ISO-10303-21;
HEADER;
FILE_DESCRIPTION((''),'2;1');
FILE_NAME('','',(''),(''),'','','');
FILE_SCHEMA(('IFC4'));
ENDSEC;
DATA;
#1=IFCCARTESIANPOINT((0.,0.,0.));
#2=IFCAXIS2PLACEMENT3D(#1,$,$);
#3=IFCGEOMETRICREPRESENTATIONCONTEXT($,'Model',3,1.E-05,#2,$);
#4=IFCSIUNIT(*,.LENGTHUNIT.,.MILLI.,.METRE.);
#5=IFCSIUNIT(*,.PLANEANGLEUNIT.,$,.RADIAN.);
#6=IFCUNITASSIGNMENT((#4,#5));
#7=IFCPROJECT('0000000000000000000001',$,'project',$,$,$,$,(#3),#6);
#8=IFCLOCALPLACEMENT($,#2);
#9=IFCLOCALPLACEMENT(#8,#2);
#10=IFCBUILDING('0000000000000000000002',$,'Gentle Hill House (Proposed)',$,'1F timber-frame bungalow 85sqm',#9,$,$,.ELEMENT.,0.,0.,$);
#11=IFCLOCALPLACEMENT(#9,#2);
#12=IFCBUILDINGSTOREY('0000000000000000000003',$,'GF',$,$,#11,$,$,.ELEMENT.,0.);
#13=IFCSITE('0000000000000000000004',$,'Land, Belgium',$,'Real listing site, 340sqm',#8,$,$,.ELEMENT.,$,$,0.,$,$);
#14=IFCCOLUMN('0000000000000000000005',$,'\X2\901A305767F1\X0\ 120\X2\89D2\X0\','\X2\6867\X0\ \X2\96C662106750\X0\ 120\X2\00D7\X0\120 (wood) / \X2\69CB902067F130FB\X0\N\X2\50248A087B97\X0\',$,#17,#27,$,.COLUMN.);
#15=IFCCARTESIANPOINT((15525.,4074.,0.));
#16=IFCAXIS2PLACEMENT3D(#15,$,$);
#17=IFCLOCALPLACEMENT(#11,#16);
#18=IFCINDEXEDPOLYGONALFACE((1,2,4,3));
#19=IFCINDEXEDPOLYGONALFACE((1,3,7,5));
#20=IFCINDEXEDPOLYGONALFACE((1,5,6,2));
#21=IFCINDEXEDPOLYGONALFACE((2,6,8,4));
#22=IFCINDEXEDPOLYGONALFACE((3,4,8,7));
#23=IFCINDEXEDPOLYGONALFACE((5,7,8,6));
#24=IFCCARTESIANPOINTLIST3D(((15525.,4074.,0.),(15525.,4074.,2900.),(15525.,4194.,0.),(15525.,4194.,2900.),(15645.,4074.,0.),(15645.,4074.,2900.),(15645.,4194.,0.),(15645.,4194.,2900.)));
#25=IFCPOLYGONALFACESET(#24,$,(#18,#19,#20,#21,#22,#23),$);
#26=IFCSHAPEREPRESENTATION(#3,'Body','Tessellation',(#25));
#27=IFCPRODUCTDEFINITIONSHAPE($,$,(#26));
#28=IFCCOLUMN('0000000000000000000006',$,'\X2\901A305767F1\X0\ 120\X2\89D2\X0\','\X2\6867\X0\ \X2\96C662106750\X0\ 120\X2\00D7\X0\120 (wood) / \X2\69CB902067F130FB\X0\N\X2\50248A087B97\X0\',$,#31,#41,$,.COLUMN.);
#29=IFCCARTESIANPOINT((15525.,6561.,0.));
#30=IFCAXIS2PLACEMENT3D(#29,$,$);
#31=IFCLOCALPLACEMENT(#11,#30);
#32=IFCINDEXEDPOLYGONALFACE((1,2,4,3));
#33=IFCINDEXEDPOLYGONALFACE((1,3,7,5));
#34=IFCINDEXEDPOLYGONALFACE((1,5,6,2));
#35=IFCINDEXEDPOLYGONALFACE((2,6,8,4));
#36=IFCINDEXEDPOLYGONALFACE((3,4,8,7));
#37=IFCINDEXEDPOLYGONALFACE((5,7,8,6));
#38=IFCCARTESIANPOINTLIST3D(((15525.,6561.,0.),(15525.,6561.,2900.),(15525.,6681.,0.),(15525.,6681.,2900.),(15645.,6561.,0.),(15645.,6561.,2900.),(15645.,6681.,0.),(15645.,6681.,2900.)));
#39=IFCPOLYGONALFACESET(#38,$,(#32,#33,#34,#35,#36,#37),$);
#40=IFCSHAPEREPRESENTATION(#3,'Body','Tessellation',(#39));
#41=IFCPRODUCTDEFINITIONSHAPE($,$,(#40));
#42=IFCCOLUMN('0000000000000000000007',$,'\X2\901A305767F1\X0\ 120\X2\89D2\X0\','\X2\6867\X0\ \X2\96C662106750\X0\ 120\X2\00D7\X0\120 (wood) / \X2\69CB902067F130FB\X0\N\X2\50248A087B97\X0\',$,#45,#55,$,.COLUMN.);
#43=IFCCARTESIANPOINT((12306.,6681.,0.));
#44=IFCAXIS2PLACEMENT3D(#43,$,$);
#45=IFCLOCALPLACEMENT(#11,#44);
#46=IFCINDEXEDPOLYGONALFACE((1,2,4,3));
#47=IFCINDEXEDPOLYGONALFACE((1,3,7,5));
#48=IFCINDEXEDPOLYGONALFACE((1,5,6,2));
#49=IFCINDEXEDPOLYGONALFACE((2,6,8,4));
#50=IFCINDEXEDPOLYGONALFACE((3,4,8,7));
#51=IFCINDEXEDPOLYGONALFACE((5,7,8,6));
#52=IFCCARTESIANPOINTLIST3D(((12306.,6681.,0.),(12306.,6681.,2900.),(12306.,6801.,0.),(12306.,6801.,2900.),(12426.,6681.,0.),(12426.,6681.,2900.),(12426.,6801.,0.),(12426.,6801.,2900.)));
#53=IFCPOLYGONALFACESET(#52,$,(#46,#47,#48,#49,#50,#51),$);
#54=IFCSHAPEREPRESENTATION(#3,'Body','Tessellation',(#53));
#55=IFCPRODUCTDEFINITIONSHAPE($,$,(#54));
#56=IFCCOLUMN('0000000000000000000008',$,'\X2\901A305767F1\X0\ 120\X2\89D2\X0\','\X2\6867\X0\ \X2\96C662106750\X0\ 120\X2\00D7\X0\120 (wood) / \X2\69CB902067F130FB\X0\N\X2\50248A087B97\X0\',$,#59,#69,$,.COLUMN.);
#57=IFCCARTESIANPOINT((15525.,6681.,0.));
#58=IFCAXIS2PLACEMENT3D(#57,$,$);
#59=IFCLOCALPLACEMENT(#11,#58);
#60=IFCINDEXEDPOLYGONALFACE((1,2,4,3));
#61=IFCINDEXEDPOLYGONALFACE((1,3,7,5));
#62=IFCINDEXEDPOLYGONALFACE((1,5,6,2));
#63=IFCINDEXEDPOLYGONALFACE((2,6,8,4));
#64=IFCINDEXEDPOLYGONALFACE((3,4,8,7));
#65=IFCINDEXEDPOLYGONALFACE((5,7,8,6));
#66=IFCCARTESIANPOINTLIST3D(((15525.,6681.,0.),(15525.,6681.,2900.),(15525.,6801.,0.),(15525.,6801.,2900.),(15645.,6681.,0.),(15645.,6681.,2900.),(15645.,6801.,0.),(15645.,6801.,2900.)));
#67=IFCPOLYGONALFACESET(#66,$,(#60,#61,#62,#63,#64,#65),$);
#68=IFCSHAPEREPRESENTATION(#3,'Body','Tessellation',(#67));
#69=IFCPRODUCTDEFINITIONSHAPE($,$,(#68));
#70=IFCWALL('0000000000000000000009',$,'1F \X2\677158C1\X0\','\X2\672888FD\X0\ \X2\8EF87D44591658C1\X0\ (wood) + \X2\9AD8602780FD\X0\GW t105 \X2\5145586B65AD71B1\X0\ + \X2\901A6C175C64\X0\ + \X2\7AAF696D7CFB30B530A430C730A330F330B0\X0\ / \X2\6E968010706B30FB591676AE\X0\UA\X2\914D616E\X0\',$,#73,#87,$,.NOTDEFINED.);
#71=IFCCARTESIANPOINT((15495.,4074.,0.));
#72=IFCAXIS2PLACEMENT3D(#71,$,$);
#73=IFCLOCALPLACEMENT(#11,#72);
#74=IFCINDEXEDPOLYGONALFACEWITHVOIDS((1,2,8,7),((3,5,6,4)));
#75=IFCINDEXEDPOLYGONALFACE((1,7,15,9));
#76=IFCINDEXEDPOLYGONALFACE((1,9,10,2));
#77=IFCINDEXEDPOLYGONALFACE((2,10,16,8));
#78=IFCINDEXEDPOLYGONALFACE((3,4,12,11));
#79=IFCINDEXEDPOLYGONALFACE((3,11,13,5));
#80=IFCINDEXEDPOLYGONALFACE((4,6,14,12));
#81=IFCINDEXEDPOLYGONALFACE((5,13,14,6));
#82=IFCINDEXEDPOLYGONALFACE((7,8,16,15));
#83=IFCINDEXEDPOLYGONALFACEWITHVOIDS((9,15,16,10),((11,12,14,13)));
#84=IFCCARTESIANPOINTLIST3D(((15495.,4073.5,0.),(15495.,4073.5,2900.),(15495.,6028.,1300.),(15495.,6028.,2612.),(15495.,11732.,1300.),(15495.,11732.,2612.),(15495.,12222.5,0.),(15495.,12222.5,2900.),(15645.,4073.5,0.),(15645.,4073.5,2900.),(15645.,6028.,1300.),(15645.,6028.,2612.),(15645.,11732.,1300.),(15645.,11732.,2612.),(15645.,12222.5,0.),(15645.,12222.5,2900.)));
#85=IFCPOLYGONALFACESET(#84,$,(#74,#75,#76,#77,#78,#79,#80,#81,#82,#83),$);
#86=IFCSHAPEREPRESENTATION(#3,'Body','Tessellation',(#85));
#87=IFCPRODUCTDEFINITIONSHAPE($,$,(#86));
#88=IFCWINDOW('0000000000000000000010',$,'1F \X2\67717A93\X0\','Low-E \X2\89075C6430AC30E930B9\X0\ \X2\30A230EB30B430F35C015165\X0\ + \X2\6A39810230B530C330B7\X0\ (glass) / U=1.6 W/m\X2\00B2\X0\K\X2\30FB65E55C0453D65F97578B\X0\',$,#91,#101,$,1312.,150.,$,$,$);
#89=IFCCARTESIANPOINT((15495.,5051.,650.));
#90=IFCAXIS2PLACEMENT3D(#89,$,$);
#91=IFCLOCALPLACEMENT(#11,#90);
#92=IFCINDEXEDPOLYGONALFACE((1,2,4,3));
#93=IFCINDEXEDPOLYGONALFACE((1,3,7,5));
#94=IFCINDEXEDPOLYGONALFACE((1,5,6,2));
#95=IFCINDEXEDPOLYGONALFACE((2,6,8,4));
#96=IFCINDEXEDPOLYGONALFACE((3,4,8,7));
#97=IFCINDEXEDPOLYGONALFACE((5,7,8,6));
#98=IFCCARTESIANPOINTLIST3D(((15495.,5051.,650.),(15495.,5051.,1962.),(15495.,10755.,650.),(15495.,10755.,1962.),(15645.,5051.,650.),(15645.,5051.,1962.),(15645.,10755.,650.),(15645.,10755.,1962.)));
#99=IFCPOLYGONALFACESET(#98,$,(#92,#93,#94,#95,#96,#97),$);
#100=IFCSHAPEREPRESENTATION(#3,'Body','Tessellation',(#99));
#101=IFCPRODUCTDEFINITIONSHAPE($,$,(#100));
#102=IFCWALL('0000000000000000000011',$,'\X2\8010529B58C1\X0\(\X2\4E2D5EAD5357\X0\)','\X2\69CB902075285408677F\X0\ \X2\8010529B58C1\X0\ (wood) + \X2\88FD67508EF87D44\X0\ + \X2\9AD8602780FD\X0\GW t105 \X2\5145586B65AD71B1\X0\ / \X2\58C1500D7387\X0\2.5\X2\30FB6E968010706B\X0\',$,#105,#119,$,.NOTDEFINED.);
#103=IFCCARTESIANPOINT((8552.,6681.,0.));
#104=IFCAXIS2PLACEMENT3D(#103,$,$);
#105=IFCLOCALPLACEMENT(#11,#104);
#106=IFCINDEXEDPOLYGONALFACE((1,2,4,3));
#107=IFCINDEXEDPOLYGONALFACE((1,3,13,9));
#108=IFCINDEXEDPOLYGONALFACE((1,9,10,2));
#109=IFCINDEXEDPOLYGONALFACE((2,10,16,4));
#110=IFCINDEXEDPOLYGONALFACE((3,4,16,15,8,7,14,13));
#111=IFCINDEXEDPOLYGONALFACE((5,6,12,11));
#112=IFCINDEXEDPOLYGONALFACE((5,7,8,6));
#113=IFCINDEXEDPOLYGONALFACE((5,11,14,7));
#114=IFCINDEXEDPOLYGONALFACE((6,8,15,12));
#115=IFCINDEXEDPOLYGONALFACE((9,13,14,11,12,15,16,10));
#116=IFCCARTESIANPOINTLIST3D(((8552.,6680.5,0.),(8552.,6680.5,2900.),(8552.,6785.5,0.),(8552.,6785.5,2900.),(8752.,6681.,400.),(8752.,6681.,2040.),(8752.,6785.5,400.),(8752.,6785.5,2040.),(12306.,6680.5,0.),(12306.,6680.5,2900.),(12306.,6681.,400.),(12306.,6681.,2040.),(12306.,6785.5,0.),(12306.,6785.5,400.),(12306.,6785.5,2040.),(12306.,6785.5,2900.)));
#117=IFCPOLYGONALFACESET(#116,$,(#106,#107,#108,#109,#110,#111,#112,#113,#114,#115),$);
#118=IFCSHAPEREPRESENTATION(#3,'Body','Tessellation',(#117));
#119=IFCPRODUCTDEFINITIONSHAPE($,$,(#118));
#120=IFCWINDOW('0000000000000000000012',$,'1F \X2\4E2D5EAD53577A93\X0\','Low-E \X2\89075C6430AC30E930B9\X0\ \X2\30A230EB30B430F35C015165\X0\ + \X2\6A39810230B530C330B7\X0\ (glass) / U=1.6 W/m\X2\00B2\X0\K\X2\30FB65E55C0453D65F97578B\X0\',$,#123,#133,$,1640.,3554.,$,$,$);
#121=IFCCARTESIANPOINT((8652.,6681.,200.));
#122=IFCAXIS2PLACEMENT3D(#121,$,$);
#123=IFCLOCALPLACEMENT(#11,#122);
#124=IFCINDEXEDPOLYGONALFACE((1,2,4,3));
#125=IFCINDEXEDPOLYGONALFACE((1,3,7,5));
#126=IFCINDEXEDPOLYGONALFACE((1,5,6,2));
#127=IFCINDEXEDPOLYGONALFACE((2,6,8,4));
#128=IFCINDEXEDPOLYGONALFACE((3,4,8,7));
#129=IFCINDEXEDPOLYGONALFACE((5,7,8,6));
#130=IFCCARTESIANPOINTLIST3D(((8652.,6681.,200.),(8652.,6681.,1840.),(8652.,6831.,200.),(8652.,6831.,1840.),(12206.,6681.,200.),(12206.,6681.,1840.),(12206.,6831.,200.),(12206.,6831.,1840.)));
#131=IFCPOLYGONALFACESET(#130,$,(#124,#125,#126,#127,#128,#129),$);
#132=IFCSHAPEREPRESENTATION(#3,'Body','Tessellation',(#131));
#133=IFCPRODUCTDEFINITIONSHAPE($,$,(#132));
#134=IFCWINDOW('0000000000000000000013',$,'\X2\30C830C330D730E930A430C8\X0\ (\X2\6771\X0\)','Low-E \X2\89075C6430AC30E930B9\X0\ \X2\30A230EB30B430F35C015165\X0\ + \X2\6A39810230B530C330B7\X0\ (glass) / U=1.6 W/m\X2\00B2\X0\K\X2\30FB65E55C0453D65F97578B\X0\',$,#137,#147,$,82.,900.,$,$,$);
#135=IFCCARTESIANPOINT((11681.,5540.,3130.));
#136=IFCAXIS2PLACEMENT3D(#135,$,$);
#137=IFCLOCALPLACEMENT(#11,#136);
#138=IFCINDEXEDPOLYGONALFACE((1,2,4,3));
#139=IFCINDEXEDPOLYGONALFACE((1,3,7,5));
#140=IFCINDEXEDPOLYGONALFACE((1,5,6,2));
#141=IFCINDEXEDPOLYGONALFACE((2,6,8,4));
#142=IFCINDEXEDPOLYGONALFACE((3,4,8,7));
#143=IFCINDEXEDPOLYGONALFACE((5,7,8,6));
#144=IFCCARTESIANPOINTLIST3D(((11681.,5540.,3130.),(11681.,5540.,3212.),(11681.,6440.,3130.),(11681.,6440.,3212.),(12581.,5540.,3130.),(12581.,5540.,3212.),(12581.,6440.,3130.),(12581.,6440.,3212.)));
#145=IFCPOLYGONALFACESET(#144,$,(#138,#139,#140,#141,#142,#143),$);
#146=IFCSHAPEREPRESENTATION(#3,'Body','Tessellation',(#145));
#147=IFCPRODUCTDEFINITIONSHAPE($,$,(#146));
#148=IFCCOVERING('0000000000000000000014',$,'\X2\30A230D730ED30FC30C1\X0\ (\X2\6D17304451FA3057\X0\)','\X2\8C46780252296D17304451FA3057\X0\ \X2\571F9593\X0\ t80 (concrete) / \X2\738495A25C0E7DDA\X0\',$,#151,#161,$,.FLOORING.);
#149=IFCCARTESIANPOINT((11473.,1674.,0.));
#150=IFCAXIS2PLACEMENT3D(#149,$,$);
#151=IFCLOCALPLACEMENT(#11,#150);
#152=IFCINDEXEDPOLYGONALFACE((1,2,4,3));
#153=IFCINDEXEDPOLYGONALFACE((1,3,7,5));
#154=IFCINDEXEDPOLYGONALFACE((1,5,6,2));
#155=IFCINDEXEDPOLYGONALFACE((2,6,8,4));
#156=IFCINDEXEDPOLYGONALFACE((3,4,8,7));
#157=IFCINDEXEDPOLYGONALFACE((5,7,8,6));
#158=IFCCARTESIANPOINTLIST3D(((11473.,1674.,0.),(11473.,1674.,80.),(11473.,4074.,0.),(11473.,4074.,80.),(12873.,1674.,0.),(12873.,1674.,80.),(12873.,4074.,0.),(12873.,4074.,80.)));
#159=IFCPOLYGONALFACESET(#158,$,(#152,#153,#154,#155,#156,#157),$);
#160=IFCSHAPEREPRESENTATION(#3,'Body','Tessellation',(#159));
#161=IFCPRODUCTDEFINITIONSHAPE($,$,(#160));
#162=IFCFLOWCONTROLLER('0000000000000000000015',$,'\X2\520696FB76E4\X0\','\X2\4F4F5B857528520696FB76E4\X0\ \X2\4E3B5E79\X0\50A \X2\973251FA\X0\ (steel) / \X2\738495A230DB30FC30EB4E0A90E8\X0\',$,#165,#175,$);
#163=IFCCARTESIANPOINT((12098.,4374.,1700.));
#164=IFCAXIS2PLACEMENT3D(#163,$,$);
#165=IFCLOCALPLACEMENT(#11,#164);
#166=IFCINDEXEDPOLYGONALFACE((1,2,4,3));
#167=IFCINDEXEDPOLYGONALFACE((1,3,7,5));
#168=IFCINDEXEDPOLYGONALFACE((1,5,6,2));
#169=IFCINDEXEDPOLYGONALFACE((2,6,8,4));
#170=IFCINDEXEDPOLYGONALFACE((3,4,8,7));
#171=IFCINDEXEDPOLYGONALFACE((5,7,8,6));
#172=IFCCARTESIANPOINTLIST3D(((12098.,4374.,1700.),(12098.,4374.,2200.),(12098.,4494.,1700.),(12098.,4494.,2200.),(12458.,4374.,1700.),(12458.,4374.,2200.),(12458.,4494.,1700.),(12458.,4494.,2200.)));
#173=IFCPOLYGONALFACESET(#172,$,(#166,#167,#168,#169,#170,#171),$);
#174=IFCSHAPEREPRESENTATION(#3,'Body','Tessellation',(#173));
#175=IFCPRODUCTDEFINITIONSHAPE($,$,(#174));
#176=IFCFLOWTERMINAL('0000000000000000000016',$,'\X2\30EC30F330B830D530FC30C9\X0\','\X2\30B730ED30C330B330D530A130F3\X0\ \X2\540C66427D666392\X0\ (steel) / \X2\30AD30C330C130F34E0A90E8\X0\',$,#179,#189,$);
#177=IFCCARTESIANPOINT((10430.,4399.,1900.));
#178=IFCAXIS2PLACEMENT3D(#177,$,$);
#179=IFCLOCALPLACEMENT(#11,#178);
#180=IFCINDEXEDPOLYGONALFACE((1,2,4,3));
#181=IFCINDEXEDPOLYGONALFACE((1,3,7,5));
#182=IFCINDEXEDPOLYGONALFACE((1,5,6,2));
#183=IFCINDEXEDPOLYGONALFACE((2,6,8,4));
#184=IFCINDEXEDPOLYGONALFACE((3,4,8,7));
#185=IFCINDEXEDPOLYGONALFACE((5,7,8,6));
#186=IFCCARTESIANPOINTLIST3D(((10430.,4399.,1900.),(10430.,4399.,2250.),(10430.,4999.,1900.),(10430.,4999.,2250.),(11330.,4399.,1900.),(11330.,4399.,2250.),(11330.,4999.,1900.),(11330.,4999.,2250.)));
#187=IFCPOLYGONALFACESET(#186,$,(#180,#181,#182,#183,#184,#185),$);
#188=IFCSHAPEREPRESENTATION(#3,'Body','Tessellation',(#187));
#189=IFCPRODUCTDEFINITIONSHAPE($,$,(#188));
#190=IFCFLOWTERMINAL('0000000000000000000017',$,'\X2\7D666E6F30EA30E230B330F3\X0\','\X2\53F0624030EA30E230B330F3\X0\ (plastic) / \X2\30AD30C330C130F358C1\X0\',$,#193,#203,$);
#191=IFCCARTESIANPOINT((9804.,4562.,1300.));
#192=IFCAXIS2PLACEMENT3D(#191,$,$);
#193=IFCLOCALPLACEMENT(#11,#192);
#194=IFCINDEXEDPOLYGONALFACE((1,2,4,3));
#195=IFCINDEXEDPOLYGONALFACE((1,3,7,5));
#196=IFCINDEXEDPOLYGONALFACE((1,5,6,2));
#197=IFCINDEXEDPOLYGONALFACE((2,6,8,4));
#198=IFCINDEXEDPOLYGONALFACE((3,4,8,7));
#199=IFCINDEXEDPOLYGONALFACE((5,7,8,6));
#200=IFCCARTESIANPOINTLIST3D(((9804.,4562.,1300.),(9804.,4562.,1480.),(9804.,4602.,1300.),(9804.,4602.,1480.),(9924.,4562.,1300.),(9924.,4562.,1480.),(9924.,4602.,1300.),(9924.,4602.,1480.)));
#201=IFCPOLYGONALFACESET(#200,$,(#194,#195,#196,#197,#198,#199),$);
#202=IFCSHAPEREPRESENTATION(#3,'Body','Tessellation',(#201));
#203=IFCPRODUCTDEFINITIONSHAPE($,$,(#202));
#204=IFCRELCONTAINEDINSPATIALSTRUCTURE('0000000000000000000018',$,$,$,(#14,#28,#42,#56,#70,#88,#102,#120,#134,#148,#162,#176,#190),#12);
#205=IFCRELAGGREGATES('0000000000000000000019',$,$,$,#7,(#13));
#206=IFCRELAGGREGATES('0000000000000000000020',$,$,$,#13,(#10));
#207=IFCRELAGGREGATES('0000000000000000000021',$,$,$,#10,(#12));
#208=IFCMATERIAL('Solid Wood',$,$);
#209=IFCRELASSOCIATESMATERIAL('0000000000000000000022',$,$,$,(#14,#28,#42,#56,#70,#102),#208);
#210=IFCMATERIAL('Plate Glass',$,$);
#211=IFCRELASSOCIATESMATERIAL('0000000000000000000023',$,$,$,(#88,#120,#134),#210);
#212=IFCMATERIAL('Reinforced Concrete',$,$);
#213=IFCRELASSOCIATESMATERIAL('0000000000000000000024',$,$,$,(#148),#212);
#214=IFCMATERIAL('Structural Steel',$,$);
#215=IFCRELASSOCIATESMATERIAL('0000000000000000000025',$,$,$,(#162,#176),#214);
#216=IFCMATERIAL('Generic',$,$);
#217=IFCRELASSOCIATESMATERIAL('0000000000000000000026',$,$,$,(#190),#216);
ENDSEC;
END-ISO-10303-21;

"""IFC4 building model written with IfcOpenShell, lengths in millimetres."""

from ifc_helpers import new_model, si_unit, frame, frame_2d, origin, place, context, project, spatial, rectangle, extrude, material, element, fill, save


model = new_model("IFC4")

# Units and contexts
model_context = context("Model", 3, precision=1e-05, world=origin())
ifc_project = project(units=[si_unit("LENGTHUNIT", "METRE", prefix="MILLI"), si_unit("PLANEANGLEUNIT", "RADIAN")], contexts=[model_context])

# Site, building, storey
site_placement = place(None, origin())
site = spatial("IfcSite", under=ifc_project, at=site_placement, Name="Land, Belgium", ObjectType="Real listing site, 340sqm", CompositionType="ELEMENT", RefElevation=0.0)
building_placement = place(site_placement, origin())
building = spatial("IfcBuilding", under=site, at=building_placement, Name="Gentle Hill House (Proposed)", ObjectType="1F timber-frame bungalow 85sqm", CompositionType="ELEMENT", ElevationOfRefHeight=0.0, ElevationOfTerrain=0.0)
storey_placement = place(building_placement, origin())
storey = spatial("IfcBuildingStorey", under=building, at=storey_placement, Name="GF", CompositionType="ELEMENT", Elevation=0.0)

# Columns
ifc_material_1 = material(Name="Solid Wood")
column_1_placement = place(storey_placement, frame((15525.0, 4074.0, 0.0)))
element("IfcColumn", 1, at=column_1_placement, inside=storey, material=ifc_material_1, Name="通し柱 120角", Description="桧 集成材 120×120 (wood) / 構造柱・N値計算", PredefinedType="COLUMN", context=model_context, shape_type="SweptSolid", body=[
    extrude(rectangle(XDim=120.0, YDim=120.0, at=frame_2d((60.0, 60.0))), frame((15525.0, 4074.0, 0.0)), (0.0, 0.0, 1.0), 2900.0),
])
column_2_placement = place(storey_placement, frame((15525.0, 6561.0, 0.0)))
element("IfcColumn", 2, at=column_2_placement, inside=storey, material=ifc_material_1, Name="通し柱 120角", Description="桧 集成材 120×120 (wood) / 構造柱・N値計算", PredefinedType="COLUMN", context=model_context, shape_type="SweptSolid", body=[
    extrude(rectangle(XDim=120.0, YDim=120.0, at=frame_2d((60.0, 60.0))), frame((15525.0, 6561.0, 0.0)), (0.0, 0.0, 1.0), 2900.0),
])
column_3_placement = place(storey_placement, frame((12306.0, 6681.0, 0.0)))
element("IfcColumn", 3, at=column_3_placement, inside=storey, material=ifc_material_1, Name="通し柱 120角", Description="桧 集成材 120×120 (wood) / 構造柱・N値計算", PredefinedType="COLUMN", context=model_context, shape_type="SweptSolid", body=[
    extrude(rectangle(XDim=120.0, YDim=120.0, at=frame_2d((60.0, 60.0))), frame((12306.0, 6681.0, 0.0)), (0.0, 0.0, 1.0), 2900.0),
])
column_4_placement = place(storey_placement, frame((15525.0, 6681.0, 0.0)))
element("IfcColumn", 4, at=column_4_placement, inside=storey, material=ifc_material_1, Name="通し柱 120角", Description="桧 集成材 120×120 (wood) / 構造柱・N値計算", PredefinedType="COLUMN", context=model_context, shape_type="SweptSolid", body=[
    extrude(rectangle(XDim=120.0, YDim=120.0, at=frame_2d((60.0, 60.0))), frame((15525.0, 6681.0, 0.0)), (0.0, 0.0, 1.0), 2900.0),
])

# Walls, openings, windows
wall_1_placement = place(storey_placement, frame((15495.0, 4074.0, 0.0)))
wall_1 = element("IfcWall", 5, at=wall_1_placement, inside=storey, material=ifc_material_1, Name="1F 東壁", Description="木製 軸組外壁 (wood) + 高性能GW t105 充填断熱 + 通気層 + 窯業系サイディング / 準耐火・外皮UA配慮", PredefinedType="NOTDEFINED", context=model_context, shape_type="SweptSolid", body=[
    extrude(rectangle(XDim=150.0, YDim=8149.0, at=frame_2d((75.0, 4074.0))), frame((15495.0, 4074.0, 0.0)), (0.0, 0.0, 1.0), 2900.0),
])
opening_1_placement = place(storey_placement, frame((15495.0, 5051.0, 650.0)))
opening_1 = element("IfcOpeningElement", 6, at=opening_1_placement, cuts=wall_1, PredefinedType="NOTDEFINED", context=model_context, shape_type="SweptSolid", body=[
    extrude(rectangle(XDim=150.0, YDim=5704.0, at=frame_2d((75.0, 2852.0))), frame((15495.0, 5051.0, 650.0)), (0.0, 0.0, 1.0), 1312.0),
])
ifc_material_2 = material(Name="Plate Glass")
window_1_placement = place(storey_placement, frame((15495.0, 5051.0, 650.0)))
window_1 = element("IfcWindow", 7, at=window_1_placement, inside=storey, material=ifc_material_2, Name="1F 東窓", Description="Low-E 複層ガラス アルゴン封入 + 樹脂サッシ (glass) / U=1.6 W/m²K・日射取得型", OverallHeight=1312.0, OverallWidth=150.0, context=model_context, shape_type="SweptSolid", body=[
    extrude(rectangle(XDim=150.0, YDim=5704.0, at=frame_2d((75.0, 2852.0))), frame((15495.0, 5051.0, 650.0)), (0.0, 0.0, 1.0), 1312.0),
])
fill(opening_1, window_1)
wall_2_placement = place(storey_placement, frame((8552.0, 6681.0, 0.0)))
wall_2 = element("IfcWall", 8, at=wall_2_placement, inside=storey, material=ifc_material_1, Name="耐力壁(中庭南)", Description="構造用合板 耐力壁 (wood) + 製材軸組 + 高性能GW t105 充填断熱 / 壁倍率2.5・準耐火", PredefinedType="NOTDEFINED", context=model_context, shape_type="SweptSolid", body=[
    extrude(rectangle(XDim=3754.0, YDim=105.0, at=frame_2d((1877.0, 52.0))), frame((8552.0, 6681.0, 0.0)), (0.0, 0.0, 1.0), 2900.0),
])
opening_2_placement = place(storey_placement, frame((8652.0, 6681.0, 200.0)))
opening_2 = element("IfcOpeningElement", 9, at=opening_2_placement, cuts=wall_2, PredefinedType="NOTDEFINED", context=model_context, shape_type="SweptSolid", body=[
    extrude(rectangle(XDim=3554.0, YDim=150.0, at=frame_2d((1777.0, 75.0))), frame((8652.0, 6681.0, 200.0)), (0.0, 0.0, 1.0), 1640.0),
])
window_2_placement = place(storey_placement, frame((8652.0, 6681.0, 200.0)))
window_2 = element("IfcWindow", 10, at=window_2_placement, inside=storey, material=ifc_material_2, Name="1F 中庭南窓", Description="Low-E 複層ガラス アルゴン封入 + 樹脂サッシ (glass) / U=1.6 W/m²K・日射取得型", OverallHeight=1640.0, OverallWidth=3554.0, context=model_context, shape_type="SweptSolid", body=[
    extrude(rectangle(XDim=3554.0, YDim=150.0, at=frame_2d((1777.0, 75.0))), frame((8652.0, 6681.0, 200.0)), (0.0, 0.0, 1.0), 1640.0),
])
fill(opening_2, window_2)

# Window
window_3_placement = place(storey_placement, frame((11681.0, 5540.0, 3130.0)))
element("IfcWindow", 11, at=window_3_placement, inside=storey, material=ifc_material_2, Name="トップライト (東)", Description="Low-E 複層ガラス アルゴン封入 + 樹脂サッシ (glass) / U=1.6 W/m²K・日射取得型", OverallHeight=82.0, OverallWidth=900.0, context=model_context, shape_type="SweptSolid", body=[
    extrude(rectangle(XDim=900.0, YDim=900.0, at=frame_2d((450.0, 450.0))), frame((11681.0, 5540.0, 3130.0)), (0.0, 0.0, 1.0), 82.0),
])

# Shared definitions
ifc_material_3 = material(Name="Structural Steel")

# Covering
ifc_material_4 = material(Name="Reinforced Concrete")
covering_placement = place(storey_placement, frame((11473.0, 1674.0, 0.0)))
element("IfcCovering", 12, at=covering_placement, inside=storey, material=ifc_material_4, Name="アプローチ (洗い出し)", Description="豆砂利洗い出し 土間 t80 (concrete) / 玄関導線", PredefinedType="FLOORING", context=model_context, shape_type="SweptSolid", body=[
    extrude(rectangle(XDim=1400.0, YDim=2400.0, at=frame_2d((700.0, 1200.0))), frame((11473.0, 1674.0, 0.0)), (0.0, 0.0, 1.0), 80.0),
])

# Flow controller
flow_controller_placement = place(storey_placement, frame((12098.0, 4374.0, 1700.0)))
element("IfcFlowController", 13, at=flow_controller_placement, inside=storey, material=ifc_material_3, Name="分電盤", Description="住宅用分電盤 主幹50A 露出 (steel) / 玄関ホール上部", context=model_context, shape_type="SweptSolid", body=[
    extrude(rectangle(XDim=360.0, YDim=120.0, at=frame_2d((180.0, 60.0))), frame((12098.0, 4374.0, 1700.0)), (0.0, 0.0, 1.0), 500.0),
])

# Flow terminals
flow_terminal_1_placement = place(storey_placement, frame((10430.0, 4399.0, 1900.0)))
element("IfcFlowTerminal", 14, at=flow_terminal_1_placement, inside=storey, material=ifc_material_3, Name="レンジフード", Description="シロッコファン 同時給排 (steel) / キッチン上部", context=model_context, shape_type="SweptSolid", body=[
    extrude(rectangle(XDim=900.0, YDim=600.0, at=frame_2d((450.0, 300.0))), frame((10430.0, 4399.0, 1900.0)), (0.0, 0.0, 1.0), 350.0),
])
ifc_material_5 = material(Name="Generic")
flow_terminal_2_placement = place(storey_placement, frame((9804.0, 4562.0, 1300.0)))
element("IfcFlowTerminal", 15, at=flow_terminal_2_placement, inside=storey, material=ifc_material_5, Name="給湯リモコン", Description="台所リモコン (plastic) / キッチン壁", context=model_context, shape_type="SweptSolid", body=[
    extrude(rectangle(XDim=120.0, YDim=40.0, at=frame_2d((60.0, 20.0))), frame((9804.0, 4562.0, 1300.0)), (0.0, 0.0, 1.0), 180.0),
])

save(model, "model.ifc")
